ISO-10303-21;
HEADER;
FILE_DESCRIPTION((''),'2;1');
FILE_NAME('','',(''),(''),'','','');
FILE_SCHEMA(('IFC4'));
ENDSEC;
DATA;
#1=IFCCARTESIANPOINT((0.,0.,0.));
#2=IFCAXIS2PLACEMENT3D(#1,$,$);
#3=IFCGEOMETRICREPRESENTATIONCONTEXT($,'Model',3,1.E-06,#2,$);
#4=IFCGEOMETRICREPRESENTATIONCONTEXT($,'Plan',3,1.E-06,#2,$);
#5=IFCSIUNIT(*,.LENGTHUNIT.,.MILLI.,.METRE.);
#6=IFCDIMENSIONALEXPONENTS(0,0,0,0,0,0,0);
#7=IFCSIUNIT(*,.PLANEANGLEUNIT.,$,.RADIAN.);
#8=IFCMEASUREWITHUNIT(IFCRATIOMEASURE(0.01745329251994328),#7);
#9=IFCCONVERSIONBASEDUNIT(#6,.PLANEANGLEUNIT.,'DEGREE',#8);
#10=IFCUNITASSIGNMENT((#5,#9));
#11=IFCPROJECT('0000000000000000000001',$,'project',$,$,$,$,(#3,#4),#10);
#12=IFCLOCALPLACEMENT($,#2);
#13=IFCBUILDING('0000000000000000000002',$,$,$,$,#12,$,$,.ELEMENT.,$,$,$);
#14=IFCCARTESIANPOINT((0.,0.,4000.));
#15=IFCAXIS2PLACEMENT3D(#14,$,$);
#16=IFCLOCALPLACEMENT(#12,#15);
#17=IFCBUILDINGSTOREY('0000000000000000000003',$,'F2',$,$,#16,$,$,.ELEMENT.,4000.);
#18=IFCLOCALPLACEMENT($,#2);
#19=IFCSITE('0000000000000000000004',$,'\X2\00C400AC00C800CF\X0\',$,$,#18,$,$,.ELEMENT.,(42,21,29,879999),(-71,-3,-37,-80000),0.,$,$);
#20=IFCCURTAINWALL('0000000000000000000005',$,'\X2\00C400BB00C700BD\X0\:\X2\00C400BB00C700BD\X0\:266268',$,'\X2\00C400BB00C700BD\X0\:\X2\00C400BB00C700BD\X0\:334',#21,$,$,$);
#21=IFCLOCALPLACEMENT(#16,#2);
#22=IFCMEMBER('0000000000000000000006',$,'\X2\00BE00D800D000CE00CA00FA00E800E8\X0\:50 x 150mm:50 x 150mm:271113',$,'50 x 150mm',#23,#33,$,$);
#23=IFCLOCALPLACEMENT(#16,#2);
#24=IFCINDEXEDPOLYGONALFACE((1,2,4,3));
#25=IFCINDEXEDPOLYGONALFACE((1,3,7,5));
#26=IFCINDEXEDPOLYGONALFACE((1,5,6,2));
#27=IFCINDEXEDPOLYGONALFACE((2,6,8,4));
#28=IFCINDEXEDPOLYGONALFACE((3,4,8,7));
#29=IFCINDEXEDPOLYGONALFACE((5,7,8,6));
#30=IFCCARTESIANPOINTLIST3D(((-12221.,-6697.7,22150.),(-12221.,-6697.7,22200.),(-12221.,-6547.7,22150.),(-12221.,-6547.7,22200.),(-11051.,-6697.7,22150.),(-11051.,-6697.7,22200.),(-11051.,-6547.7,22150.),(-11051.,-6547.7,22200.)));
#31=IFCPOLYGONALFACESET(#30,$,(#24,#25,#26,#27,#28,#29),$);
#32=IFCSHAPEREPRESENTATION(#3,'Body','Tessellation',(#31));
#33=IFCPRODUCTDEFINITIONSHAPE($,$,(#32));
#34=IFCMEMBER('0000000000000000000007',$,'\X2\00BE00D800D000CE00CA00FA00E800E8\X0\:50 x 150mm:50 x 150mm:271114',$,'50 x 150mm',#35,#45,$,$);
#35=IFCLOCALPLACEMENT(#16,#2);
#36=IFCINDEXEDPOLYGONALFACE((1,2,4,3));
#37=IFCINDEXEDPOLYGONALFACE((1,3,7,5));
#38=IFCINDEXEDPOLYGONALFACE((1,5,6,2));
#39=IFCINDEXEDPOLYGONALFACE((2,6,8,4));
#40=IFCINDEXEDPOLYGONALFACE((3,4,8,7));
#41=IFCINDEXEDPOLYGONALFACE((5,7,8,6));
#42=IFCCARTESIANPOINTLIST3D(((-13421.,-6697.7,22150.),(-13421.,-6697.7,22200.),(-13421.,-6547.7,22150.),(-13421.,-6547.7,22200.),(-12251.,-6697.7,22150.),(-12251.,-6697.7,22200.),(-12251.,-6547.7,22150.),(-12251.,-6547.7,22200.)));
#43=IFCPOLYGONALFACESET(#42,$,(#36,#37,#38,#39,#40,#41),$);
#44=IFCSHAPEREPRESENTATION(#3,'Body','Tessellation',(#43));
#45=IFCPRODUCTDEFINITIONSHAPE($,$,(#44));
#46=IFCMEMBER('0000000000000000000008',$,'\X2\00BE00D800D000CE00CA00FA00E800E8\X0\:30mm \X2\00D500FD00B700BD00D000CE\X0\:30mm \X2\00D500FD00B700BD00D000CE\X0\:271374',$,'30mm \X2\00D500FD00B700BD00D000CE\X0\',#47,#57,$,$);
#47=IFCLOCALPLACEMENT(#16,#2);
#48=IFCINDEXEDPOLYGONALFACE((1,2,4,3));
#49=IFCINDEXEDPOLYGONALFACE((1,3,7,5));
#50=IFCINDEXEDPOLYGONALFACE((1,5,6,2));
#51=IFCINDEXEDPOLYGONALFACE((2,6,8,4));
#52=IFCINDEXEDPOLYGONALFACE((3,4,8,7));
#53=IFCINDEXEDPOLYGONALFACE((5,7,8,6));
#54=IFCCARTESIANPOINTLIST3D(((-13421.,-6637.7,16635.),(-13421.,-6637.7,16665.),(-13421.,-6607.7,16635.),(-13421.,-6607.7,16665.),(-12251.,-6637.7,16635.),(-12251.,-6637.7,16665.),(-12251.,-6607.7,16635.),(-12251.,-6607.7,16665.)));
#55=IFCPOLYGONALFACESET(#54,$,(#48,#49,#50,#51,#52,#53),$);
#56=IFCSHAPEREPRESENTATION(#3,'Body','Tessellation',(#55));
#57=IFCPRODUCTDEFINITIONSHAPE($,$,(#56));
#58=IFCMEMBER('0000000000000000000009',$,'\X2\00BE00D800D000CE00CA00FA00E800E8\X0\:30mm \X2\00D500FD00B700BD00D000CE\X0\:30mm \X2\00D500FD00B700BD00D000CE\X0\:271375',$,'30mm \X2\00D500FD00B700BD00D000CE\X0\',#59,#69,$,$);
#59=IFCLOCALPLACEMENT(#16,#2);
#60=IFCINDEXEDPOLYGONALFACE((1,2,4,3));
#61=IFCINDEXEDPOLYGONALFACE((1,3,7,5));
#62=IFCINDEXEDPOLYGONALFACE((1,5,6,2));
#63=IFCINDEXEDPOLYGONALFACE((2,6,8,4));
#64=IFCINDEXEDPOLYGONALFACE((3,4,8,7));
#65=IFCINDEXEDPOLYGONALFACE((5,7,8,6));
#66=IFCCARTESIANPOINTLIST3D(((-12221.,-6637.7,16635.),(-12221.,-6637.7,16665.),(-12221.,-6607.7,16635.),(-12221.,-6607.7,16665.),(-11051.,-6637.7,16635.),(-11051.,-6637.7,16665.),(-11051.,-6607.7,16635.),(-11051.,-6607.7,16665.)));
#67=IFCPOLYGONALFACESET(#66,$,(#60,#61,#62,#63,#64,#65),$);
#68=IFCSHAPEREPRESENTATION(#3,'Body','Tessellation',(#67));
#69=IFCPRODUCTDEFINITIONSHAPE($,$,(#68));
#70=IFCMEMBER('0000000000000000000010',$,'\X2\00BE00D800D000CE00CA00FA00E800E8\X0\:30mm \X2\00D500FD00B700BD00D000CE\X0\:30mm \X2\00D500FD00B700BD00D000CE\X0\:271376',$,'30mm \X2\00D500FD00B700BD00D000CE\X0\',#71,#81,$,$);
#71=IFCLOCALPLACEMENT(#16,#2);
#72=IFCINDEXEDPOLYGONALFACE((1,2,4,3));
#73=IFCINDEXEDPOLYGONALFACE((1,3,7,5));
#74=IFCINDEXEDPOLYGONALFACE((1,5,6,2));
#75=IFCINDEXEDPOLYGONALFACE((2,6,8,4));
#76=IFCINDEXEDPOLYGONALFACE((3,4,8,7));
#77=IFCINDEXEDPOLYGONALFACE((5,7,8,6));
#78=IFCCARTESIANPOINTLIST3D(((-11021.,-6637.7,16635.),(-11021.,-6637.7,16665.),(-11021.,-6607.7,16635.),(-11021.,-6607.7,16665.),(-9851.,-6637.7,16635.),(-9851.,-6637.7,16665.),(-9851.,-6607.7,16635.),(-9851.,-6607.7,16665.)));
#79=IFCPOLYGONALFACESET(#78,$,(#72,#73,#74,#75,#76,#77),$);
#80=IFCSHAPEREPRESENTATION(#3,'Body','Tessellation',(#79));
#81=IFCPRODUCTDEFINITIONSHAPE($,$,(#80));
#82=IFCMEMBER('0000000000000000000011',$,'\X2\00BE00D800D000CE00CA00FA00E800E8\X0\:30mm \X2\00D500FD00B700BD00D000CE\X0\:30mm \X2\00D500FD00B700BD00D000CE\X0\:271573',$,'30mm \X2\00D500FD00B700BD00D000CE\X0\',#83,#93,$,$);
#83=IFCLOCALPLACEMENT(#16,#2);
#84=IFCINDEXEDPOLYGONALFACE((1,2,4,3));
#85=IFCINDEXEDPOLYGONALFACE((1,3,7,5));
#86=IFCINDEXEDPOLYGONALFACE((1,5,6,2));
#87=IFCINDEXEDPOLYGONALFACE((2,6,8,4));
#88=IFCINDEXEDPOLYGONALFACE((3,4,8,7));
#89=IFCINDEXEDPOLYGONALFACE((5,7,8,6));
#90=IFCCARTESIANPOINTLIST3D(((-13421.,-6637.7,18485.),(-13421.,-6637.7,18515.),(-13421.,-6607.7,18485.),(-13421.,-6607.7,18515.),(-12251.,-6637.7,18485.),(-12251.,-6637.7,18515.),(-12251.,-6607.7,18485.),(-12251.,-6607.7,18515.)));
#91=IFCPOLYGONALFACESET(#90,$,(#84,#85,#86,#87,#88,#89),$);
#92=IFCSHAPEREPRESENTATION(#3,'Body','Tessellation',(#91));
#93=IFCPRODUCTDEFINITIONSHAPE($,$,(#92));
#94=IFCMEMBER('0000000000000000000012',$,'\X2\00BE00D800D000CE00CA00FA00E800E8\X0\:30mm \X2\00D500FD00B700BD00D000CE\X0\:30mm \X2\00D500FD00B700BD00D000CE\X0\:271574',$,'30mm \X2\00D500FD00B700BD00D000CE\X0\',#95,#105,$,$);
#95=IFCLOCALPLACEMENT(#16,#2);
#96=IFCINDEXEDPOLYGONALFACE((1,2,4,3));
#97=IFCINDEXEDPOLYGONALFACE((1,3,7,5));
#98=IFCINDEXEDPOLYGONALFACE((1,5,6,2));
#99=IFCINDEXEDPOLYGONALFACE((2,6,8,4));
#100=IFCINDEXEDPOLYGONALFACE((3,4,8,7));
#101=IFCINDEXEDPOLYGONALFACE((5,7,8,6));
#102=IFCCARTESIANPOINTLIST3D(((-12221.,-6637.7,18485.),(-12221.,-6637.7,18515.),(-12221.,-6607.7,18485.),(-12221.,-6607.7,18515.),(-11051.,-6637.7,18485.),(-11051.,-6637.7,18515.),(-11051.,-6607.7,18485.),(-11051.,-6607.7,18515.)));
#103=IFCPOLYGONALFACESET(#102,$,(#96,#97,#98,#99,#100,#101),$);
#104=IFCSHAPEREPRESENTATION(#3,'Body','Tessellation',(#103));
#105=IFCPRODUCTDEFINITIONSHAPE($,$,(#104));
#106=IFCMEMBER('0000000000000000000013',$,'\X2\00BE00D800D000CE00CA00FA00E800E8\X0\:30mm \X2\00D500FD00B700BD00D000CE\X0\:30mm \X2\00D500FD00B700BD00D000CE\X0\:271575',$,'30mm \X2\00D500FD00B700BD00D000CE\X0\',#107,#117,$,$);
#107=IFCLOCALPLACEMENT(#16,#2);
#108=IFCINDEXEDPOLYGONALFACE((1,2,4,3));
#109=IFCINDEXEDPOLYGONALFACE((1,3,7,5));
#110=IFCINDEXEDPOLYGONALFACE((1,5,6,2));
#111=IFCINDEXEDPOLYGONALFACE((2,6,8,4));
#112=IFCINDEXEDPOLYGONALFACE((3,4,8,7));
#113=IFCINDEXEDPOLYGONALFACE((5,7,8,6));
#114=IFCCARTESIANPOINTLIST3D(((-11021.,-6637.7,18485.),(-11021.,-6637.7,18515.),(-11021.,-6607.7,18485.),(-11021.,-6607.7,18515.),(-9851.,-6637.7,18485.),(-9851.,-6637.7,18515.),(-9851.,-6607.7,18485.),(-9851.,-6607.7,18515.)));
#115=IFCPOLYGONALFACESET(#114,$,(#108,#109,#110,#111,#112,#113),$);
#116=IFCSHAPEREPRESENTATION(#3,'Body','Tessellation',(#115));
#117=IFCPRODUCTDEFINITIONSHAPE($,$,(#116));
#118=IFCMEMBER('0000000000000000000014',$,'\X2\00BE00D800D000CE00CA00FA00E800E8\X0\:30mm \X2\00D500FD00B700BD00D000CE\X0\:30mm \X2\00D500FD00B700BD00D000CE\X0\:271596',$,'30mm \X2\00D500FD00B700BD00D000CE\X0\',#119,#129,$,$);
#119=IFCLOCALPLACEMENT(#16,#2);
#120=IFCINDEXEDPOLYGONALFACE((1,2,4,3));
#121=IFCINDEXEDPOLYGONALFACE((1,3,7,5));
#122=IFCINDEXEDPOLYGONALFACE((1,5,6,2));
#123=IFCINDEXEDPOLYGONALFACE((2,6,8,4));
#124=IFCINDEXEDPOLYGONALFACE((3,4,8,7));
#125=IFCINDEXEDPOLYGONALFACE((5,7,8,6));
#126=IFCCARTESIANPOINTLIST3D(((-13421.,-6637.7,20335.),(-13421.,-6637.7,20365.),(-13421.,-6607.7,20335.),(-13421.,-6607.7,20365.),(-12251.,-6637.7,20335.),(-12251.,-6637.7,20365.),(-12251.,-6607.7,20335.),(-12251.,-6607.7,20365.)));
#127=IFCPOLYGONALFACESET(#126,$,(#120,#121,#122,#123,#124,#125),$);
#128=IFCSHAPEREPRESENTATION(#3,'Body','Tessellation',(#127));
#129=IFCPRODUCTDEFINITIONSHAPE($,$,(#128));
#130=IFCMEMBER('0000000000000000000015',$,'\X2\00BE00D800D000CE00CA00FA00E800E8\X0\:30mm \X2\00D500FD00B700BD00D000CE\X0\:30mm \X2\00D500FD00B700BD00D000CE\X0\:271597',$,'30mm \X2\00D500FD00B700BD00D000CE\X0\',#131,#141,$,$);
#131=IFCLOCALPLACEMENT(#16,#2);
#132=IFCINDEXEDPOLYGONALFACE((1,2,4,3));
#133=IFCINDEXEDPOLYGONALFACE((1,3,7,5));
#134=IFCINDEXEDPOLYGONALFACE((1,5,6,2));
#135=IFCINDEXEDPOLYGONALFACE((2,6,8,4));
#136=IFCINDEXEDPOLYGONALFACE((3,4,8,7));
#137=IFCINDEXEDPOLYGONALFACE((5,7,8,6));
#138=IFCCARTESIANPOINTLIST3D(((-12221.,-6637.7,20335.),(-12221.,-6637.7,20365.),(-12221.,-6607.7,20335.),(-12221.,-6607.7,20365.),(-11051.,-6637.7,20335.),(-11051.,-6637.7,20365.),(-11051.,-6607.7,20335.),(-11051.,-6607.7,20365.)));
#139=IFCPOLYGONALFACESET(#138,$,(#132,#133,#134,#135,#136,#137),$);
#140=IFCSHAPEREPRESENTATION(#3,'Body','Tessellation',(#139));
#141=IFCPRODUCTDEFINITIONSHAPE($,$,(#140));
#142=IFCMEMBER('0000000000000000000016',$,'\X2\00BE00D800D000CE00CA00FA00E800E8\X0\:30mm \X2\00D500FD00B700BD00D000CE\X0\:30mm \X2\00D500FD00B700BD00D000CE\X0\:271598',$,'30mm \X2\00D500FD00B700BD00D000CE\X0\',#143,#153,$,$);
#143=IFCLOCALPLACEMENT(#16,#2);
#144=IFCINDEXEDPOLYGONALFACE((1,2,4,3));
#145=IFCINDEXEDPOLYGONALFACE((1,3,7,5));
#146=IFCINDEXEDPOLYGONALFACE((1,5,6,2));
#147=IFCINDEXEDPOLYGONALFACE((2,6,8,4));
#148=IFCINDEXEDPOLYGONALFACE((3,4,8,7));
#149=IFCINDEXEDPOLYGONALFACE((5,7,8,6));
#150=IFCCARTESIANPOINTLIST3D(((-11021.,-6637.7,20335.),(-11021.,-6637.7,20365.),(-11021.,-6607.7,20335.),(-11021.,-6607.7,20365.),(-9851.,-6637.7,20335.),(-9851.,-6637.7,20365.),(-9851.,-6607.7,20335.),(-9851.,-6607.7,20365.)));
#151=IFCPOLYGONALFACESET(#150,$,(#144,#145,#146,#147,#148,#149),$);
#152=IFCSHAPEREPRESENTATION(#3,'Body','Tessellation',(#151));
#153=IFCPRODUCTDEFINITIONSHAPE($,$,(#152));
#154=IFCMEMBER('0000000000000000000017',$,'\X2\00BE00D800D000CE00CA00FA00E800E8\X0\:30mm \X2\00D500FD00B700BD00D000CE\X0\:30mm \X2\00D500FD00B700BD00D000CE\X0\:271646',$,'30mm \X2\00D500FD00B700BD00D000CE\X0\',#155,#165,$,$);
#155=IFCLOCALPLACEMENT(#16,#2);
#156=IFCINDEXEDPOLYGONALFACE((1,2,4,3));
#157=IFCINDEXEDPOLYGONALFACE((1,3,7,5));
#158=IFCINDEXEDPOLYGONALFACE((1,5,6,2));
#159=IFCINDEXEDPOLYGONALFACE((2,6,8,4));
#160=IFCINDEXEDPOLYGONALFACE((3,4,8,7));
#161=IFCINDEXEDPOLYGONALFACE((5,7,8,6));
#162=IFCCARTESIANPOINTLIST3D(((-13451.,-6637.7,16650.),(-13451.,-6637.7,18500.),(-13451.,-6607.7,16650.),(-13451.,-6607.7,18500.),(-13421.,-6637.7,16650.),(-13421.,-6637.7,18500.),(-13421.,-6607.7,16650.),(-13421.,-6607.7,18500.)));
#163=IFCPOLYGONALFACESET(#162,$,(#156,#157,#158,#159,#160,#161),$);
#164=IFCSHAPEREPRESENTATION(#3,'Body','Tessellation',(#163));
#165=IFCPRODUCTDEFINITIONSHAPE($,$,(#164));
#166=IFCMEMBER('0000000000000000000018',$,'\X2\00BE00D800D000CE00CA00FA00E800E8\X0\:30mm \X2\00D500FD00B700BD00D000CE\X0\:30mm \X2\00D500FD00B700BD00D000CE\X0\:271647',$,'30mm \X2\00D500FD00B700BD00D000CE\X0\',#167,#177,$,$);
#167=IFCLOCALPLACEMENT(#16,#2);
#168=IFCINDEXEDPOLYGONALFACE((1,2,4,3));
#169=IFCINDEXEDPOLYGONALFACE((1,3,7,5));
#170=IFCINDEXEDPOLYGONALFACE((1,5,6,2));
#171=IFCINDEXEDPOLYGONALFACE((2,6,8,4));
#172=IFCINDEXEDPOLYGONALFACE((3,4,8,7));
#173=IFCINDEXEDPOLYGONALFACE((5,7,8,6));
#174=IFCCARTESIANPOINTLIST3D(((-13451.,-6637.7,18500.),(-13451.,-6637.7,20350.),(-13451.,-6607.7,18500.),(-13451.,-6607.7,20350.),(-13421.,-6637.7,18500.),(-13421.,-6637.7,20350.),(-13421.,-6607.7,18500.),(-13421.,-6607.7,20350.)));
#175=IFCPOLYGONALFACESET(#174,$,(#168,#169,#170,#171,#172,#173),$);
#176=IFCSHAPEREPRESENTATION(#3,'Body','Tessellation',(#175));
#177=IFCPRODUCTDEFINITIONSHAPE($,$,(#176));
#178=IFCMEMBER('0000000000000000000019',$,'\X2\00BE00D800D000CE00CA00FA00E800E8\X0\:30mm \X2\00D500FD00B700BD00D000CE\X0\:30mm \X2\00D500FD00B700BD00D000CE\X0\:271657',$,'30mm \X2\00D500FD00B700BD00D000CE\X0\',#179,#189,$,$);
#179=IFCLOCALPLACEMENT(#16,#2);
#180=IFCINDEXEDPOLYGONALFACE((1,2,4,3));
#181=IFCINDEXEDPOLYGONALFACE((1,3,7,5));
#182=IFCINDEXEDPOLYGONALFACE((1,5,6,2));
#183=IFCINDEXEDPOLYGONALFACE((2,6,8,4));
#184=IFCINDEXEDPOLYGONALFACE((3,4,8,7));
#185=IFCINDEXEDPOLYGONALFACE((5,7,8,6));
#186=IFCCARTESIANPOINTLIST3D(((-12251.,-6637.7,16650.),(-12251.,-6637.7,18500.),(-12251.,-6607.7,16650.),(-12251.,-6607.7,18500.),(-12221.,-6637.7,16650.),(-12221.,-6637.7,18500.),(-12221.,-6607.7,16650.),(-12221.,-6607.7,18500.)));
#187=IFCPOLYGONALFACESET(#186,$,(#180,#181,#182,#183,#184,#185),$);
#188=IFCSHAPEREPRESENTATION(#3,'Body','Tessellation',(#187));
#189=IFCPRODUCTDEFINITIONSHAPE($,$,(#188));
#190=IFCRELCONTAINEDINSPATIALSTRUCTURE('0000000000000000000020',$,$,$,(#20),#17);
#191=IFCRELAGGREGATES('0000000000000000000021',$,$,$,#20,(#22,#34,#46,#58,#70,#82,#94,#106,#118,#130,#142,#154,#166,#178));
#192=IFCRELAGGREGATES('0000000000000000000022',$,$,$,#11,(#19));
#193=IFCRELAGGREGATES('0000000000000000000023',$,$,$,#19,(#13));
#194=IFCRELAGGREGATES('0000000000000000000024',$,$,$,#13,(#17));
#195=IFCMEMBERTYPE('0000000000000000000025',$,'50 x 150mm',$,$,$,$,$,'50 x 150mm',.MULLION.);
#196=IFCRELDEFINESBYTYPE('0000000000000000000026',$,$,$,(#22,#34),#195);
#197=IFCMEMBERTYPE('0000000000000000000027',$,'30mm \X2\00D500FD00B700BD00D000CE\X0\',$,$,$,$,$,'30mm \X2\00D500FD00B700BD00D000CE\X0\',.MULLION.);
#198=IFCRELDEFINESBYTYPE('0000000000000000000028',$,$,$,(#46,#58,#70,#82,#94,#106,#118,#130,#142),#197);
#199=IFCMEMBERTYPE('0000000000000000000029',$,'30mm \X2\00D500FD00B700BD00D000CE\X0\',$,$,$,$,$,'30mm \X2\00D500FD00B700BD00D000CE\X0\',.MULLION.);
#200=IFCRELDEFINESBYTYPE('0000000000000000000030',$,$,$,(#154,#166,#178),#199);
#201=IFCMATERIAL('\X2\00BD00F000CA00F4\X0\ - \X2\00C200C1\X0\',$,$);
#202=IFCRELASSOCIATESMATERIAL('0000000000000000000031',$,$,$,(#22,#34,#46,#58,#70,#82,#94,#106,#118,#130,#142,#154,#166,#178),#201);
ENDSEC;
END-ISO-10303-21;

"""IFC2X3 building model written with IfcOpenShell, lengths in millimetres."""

from ifc_helpers import new_model, entity, si_unit, converted_unit, frame, origin, origin_2d_with_axis, place, context, project, spatial, rectangle, extrude, source, transform, mapped, material, type_object, type_shapes, element, aggregate, save


model = new_model("IFC2X3")

# Units and contexts
model_context = context("Model", 3, precision=1e-06, world=origin())
plan_context = context("Plan", 3, precision=1e-06, world=origin())
ifc_project = project(units=[si_unit("LENGTHUNIT", "METRE", prefix="MILLI"), converted_unit("PLANEANGLEUNIT", "DEGREE", entity("IfcRatioMeasure", 0.01745329251994328), si_unit("PLANEANGLEUNIT", "RADIAN"), dimensions=[0, 0, 0, 0, 0, 0, 0])], contexts=[model_context, plan_context])

# Site, building, storey
site_placement = place(None, origin())
site = spatial("IfcSite", under=ifc_project, at=site_placement, Name="Ä¬ÈÏ", CompositionType="ELEMENT", RefLatitude=(42, 21, 29, 879999), RefLongitude=(-71, -3, -37, -80000), RefElevation=0.0)
building_placement = place(None, origin())
building = spatial("IfcBuilding", under=site, at=building_placement, CompositionType="ELEMENT")
storey_placement = place(building_placement, frame((0.0, 0.0, 4000.0)))
storey = spatial("IfcBuildingStorey", under=building, at=storey_placement, Name="F2", CompositionType="ELEMENT", Elevation=4000.0)

# Curtain wall, members
curtain_wall_placement = place(storey_placement, origin())
curtain_wall = element("IfcCurtainWall", 1, at=curtain_wall_placement, inside=storey, Name="Ä»Ç½:Ä»Ç½:266268", ObjectType="Ä»Ç½:Ä»Ç½:334")
ifc_material_1 = material(Name="½ðÊô - ÂÁ")
member_type_1 = type_object("IfcMemberType", Name="50 x 150mm", ElementType="50 x 150mm", PredefinedType="MULLION")
shared_shape_1 = source(origin(), model_context, "Body", "SweptSolid", [
    extrude(rectangle(XDim=50.0, YDim=150.0, at=origin_2d_with_axis()), frame((-25.0, 0.0, -1170.0), z_axis=(0.0, 0.0, 1.0), x_axis=(-1.0, 0.0, 0.0)), (0.0, 0.0, 1.0), 1170.0),
])
type_shapes(member_type_1, [shared_shape_1])
placement_1 = place(building_placement, frame((0.0, 0.0, 26200.0)))
member_1_placement = place(placement_1, frame((-11051.0, -6622.7, 0.0), z_axis=(1.0, 0.0, 0.0), x_axis=(0.0, 0.0, 1.0)))
member_1 = element("IfcMember", 2, at=member_1_placement, type_object=member_type_1, material=ifc_material_1, Name="¾ØÐÎÊúèè:50 x 150mm:50 x 150mm:271113", ObjectType="50 x 150mm", context=model_context, shape_type="MappedRepresentation", body=[
    mapped(shared_shape_1, transform((0.0, 0.0, 0.0), scale=1.0)),
])
member_2_placement = place(placement_1, frame((-12251.0, -6622.7, 0.0), z_axis=(1.0, 0.0, 0.0), x_axis=(0.0, 0.0, 1.0)))
member_2 = element("IfcMember", 3, at=member_2_placement, type_object=member_type_1, material=ifc_material_1, Name="¾ØÐÎÊúèè:50 x 150mm:50 x 150mm:271114", ObjectType="50 x 150mm", context=model_context, shape_type="MappedRepresentation", body=[
    mapped(shared_shape_1, transform((0.0, 0.0, 0.0), scale=1.0)),
])
member_type_2 = type_object("IfcMemberType", Name="30mm Õý·½ÐÎ", ElementType="30mm Õý·½ÐÎ", PredefinedType="MULLION")
shared_shape_2 = source(origin(), model_context, "Body", "SweptSolid", [
    extrude(rectangle(XDim=30.0, YDim=30.0, at=origin_2d_with_axis()), frame((0.0, 0.0, -1170.0), z_axis=(0.0, 0.0, 1.0), x_axis=(-1.0, 0.0, 0.0)), (0.0, 0.0, 1.0), 1170.0),
])
type_shapes(member_type_2, [shared_shape_2])
placement_2 = place(building_placement, frame((0.0, 0.0, 18800.0)))
member_3_placement = place(placement_2, frame((-12251.0, -6622.7, 1850.0), z_axis=(1.0, 0.0, 0.0), x_axis=(0.0, 0.0, 1.0)))
member_3 = element("IfcMember", 4, at=member_3_placement, type_object=member_type_2, material=ifc_material_1, Name="¾ØÐÎÊúèè:30mm Õý·½ÐÎ:30mm Õý·½ÐÎ:271374", ObjectType="30mm Õý·½ÐÎ", context=model_context, shape_type="MappedRepresentation", body=[
    mapped(shared_shape_2, transform((0.0, 0.0, 0.0), scale=1.0)),
])
member_4_placement = place(placement_2, frame((-11051.0, -6622.7, 1850.0), z_axis=(1.0, 0.0, 0.0), x_axis=(0.0, 0.0, 1.0)))
member_4 = element("IfcMember", 5, at=member_4_placement, type_object=member_type_2, material=ifc_material_1, Name="¾ØÐÎÊúèè:30mm Õý·½ÐÎ:30mm Õý·½ÐÎ:271375", ObjectType="30mm Õý·½ÐÎ", context=model_context, shape_type="MappedRepresentation", body=[
    mapped(shared_shape_2, transform((0.0, 0.0, 0.0), scale=1.0)),
])
member_5_placement = place(placement_2, frame((-9851.0, -6622.7, 1850.0), z_axis=(1.0, 0.0, 0.0), x_axis=(0.0, 0.0, 1.0)))
member_5 = element("IfcMember", 6, at=member_5_placement, type_object=member_type_2, material=ifc_material_1, Name="¾ØÐÎÊúèè:30mm Õý·½ÐÎ:30mm Õý·½ÐÎ:271376", ObjectType="30mm Õý·½ÐÎ", context=model_context, shape_type="MappedRepresentation", body=[
    mapped(shared_shape_2, transform((0.0, 0.0, 0.0), scale=1.0)),
])
placement_3 = place(building_placement, frame((0.0, 0.0, 22500.0)))
member_6_placement = place(placement_3, frame((-12251.0, -6622.7, 0.0), z_axis=(1.0, 0.0, 0.0), x_axis=(0.0, 0.0, 1.0)))
member_6 = element("IfcMember", 7, at=member_6_placement, type_object=member_type_2, material=ifc_material_1, Name="¾ØÐÎÊúèè:30mm Õý·½ÐÎ:30mm Õý·½ÐÎ:271573", ObjectType="30mm Õý·½ÐÎ", context=model_context, shape_type="MappedRepresentation", body=[
    mapped(shared_shape_2, transform((0.0, 0.0, 0.0), scale=1.0)),
])
member_7_placement = place(placement_3, frame((-11051.0, -6622.7, 0.0), z_axis=(1.0, 0.0, 0.0), x_axis=(0.0, 0.0, 1.0)))
member_7 = element("IfcMember", 8, at=member_7_placement, type_object=member_type_2, material=ifc_material_1, Name="¾ØÐÎÊúèè:30mm Õý·½ÐÎ:30mm Õý·½ÐÎ:271574", ObjectType="30mm Õý·½ÐÎ", context=model_context, shape_type="MappedRepresentation", body=[
    mapped(shared_shape_2, transform((0.0, 0.0, 0.0), scale=1.0)),
])
member_8_placement = place(placement_3, frame((-9851.0, -6622.7, 0.0), z_axis=(1.0, 0.0, 0.0), x_axis=(0.0, 0.0, 1.0)))
member_8 = element("IfcMember", 9, at=member_8_placement, type_object=member_type_2, material=ifc_material_1, Name="¾ØÐÎÊúèè:30mm Õý·½ÐÎ:30mm Õý·½ÐÎ:271575", ObjectType="30mm Õý·½ÐÎ", context=model_context, shape_type="MappedRepresentation", body=[
    mapped(shared_shape_2, transform((0.0, 0.0, 0.0), scale=1.0)),
])
member_9_placement = place(placement_3, frame((-12251.0, -6622.7, 1850.0), z_axis=(1.0, 0.0, 0.0), x_axis=(0.0, 0.0, 1.0)))
member_9 = element("IfcMember", 10, at=member_9_placement, type_object=member_type_2, material=ifc_material_1, Name="¾ØÐÎÊúèè:30mm Õý·½ÐÎ:30mm Õý·½ÐÎ:271596", ObjectType="30mm Õý·½ÐÎ", context=model_context, shape_type="MappedRepresentation", body=[
    mapped(shared_shape_2, transform((0.0, 0.0, 0.0), scale=1.0)),
])
member_10_placement = place(placement_3, frame((-11051.0, -6622.7, 1850.0), z_axis=(1.0, 0.0, 0.0), x_axis=(0.0, 0.0, 1.0)))
member_10 = element("IfcMember", 11, at=member_10_placement, type_object=member_type_2, material=ifc_material_1, Name="¾ØÐÎÊúèè:30mm Õý·½ÐÎ:30mm Õý·½ÐÎ:271597", ObjectType="30mm Õý·½ÐÎ", context=model_context, shape_type="MappedRepresentation", body=[
    mapped(shared_shape_2, transform((0.0, 0.0, 0.0), scale=1.0)),
])
member_11_placement = place(placement_3, frame((-9851.0, -6622.7, 1850.0), z_axis=(1.0, 0.0, 0.0), x_axis=(0.0, 0.0, 1.0)))
member_11 = element("IfcMember", 12, at=member_11_placement, type_object=member_type_2, material=ifc_material_1, Name="¾ØÐÎÊúèè:30mm Õý·½ÐÎ:30mm Õý·½ÐÎ:271598", ObjectType="30mm Õý·½ÐÎ", context=model_context, shape_type="MappedRepresentation", body=[
    mapped(shared_shape_2, transform((0.0, 0.0, 0.0), scale=1.0)),
])
member_type_3 = type_object("IfcMemberType", Name="30mm Õý·½ÐÎ", ElementType="30mm Õý·½ÐÎ", PredefinedType="MULLION")
shared_shape_3 = source(origin(), model_context, "Body", "SweptSolid", [
    extrude(rectangle(XDim=30.0, YDim=30.0, at=origin_2d_with_axis()), frame((0.0, 0.0, -1850.0), z_axis=(0.0, 0.0, 1.0), x_axis=(-1.0, 0.0, 0.0)), (0.0, 0.0, 1.0), 1850.0),
])
type_shapes(member_type_3, [shared_shape_3])
member_12_placement = place(placement_2, frame((-13436.0, -6622.7, 1850.0), z_axis=(0.0, 0.0, -1.0), x_axis=(1.0, 0.0, 0.0)))
member_12 = element("IfcMember", 13, at=member_12_placement, type_object=member_type_3, material=ifc_material_1, Name="¾ØÐÎÊúèè:30mm Õý·½ÐÎ:30mm Õý·½ÐÎ:271646", ObjectType="30mm Õý·½ÐÎ", context=model_context, shape_type="MappedRepresentation", body=[
    mapped(shared_shape_3, transform((0.0, 0.0, 0.0), scale=1.0)),
])
member_13_placement = place(placement_3, frame((-13436.0, -6622.7, 0.0), z_axis=(0.0, 0.0, -1.0), x_axis=(1.0, 0.0, 0.0)))
member_13 = element("IfcMember", 14, at=member_13_placement, type_object=member_type_3, material=ifc_material_1, Name="¾ØÐÎÊúèè:30mm Õý·½ÐÎ:30mm Õý·½ÐÎ:271647", ObjectType="30mm Õý·½ÐÎ", context=model_context, shape_type="MappedRepresentation", body=[
    mapped(shared_shape_3, transform((0.0, 0.0, 0.0), scale=1.0)),
])
member_14_placement = place(placement_2, frame((-12236.0, -6622.7, 1850.0), z_axis=(0.0, 0.0, -1.0), x_axis=(1.0, 0.0, 0.0)))
member_14 = element("IfcMember", 15, at=member_14_placement, type_object=member_type_3, material=ifc_material_1, Name="¾ØÐÎÊúèè:30mm Õý·½ÐÎ:30mm Õý·½ÐÎ:271657", ObjectType="30mm Õý·½ÐÎ", context=model_context, shape_type="MappedRepresentation", body=[
    mapped(shared_shape_3, transform((0.0, 0.0, 0.0), scale=1.0)),
])
aggregate(curtain_wall, [member_1, member_2, member_3, member_4, member_5, member_6, member_7, member_8, member_9, member_10, member_11, member_12, member_13, member_14])

save(model, "model.ifc")
